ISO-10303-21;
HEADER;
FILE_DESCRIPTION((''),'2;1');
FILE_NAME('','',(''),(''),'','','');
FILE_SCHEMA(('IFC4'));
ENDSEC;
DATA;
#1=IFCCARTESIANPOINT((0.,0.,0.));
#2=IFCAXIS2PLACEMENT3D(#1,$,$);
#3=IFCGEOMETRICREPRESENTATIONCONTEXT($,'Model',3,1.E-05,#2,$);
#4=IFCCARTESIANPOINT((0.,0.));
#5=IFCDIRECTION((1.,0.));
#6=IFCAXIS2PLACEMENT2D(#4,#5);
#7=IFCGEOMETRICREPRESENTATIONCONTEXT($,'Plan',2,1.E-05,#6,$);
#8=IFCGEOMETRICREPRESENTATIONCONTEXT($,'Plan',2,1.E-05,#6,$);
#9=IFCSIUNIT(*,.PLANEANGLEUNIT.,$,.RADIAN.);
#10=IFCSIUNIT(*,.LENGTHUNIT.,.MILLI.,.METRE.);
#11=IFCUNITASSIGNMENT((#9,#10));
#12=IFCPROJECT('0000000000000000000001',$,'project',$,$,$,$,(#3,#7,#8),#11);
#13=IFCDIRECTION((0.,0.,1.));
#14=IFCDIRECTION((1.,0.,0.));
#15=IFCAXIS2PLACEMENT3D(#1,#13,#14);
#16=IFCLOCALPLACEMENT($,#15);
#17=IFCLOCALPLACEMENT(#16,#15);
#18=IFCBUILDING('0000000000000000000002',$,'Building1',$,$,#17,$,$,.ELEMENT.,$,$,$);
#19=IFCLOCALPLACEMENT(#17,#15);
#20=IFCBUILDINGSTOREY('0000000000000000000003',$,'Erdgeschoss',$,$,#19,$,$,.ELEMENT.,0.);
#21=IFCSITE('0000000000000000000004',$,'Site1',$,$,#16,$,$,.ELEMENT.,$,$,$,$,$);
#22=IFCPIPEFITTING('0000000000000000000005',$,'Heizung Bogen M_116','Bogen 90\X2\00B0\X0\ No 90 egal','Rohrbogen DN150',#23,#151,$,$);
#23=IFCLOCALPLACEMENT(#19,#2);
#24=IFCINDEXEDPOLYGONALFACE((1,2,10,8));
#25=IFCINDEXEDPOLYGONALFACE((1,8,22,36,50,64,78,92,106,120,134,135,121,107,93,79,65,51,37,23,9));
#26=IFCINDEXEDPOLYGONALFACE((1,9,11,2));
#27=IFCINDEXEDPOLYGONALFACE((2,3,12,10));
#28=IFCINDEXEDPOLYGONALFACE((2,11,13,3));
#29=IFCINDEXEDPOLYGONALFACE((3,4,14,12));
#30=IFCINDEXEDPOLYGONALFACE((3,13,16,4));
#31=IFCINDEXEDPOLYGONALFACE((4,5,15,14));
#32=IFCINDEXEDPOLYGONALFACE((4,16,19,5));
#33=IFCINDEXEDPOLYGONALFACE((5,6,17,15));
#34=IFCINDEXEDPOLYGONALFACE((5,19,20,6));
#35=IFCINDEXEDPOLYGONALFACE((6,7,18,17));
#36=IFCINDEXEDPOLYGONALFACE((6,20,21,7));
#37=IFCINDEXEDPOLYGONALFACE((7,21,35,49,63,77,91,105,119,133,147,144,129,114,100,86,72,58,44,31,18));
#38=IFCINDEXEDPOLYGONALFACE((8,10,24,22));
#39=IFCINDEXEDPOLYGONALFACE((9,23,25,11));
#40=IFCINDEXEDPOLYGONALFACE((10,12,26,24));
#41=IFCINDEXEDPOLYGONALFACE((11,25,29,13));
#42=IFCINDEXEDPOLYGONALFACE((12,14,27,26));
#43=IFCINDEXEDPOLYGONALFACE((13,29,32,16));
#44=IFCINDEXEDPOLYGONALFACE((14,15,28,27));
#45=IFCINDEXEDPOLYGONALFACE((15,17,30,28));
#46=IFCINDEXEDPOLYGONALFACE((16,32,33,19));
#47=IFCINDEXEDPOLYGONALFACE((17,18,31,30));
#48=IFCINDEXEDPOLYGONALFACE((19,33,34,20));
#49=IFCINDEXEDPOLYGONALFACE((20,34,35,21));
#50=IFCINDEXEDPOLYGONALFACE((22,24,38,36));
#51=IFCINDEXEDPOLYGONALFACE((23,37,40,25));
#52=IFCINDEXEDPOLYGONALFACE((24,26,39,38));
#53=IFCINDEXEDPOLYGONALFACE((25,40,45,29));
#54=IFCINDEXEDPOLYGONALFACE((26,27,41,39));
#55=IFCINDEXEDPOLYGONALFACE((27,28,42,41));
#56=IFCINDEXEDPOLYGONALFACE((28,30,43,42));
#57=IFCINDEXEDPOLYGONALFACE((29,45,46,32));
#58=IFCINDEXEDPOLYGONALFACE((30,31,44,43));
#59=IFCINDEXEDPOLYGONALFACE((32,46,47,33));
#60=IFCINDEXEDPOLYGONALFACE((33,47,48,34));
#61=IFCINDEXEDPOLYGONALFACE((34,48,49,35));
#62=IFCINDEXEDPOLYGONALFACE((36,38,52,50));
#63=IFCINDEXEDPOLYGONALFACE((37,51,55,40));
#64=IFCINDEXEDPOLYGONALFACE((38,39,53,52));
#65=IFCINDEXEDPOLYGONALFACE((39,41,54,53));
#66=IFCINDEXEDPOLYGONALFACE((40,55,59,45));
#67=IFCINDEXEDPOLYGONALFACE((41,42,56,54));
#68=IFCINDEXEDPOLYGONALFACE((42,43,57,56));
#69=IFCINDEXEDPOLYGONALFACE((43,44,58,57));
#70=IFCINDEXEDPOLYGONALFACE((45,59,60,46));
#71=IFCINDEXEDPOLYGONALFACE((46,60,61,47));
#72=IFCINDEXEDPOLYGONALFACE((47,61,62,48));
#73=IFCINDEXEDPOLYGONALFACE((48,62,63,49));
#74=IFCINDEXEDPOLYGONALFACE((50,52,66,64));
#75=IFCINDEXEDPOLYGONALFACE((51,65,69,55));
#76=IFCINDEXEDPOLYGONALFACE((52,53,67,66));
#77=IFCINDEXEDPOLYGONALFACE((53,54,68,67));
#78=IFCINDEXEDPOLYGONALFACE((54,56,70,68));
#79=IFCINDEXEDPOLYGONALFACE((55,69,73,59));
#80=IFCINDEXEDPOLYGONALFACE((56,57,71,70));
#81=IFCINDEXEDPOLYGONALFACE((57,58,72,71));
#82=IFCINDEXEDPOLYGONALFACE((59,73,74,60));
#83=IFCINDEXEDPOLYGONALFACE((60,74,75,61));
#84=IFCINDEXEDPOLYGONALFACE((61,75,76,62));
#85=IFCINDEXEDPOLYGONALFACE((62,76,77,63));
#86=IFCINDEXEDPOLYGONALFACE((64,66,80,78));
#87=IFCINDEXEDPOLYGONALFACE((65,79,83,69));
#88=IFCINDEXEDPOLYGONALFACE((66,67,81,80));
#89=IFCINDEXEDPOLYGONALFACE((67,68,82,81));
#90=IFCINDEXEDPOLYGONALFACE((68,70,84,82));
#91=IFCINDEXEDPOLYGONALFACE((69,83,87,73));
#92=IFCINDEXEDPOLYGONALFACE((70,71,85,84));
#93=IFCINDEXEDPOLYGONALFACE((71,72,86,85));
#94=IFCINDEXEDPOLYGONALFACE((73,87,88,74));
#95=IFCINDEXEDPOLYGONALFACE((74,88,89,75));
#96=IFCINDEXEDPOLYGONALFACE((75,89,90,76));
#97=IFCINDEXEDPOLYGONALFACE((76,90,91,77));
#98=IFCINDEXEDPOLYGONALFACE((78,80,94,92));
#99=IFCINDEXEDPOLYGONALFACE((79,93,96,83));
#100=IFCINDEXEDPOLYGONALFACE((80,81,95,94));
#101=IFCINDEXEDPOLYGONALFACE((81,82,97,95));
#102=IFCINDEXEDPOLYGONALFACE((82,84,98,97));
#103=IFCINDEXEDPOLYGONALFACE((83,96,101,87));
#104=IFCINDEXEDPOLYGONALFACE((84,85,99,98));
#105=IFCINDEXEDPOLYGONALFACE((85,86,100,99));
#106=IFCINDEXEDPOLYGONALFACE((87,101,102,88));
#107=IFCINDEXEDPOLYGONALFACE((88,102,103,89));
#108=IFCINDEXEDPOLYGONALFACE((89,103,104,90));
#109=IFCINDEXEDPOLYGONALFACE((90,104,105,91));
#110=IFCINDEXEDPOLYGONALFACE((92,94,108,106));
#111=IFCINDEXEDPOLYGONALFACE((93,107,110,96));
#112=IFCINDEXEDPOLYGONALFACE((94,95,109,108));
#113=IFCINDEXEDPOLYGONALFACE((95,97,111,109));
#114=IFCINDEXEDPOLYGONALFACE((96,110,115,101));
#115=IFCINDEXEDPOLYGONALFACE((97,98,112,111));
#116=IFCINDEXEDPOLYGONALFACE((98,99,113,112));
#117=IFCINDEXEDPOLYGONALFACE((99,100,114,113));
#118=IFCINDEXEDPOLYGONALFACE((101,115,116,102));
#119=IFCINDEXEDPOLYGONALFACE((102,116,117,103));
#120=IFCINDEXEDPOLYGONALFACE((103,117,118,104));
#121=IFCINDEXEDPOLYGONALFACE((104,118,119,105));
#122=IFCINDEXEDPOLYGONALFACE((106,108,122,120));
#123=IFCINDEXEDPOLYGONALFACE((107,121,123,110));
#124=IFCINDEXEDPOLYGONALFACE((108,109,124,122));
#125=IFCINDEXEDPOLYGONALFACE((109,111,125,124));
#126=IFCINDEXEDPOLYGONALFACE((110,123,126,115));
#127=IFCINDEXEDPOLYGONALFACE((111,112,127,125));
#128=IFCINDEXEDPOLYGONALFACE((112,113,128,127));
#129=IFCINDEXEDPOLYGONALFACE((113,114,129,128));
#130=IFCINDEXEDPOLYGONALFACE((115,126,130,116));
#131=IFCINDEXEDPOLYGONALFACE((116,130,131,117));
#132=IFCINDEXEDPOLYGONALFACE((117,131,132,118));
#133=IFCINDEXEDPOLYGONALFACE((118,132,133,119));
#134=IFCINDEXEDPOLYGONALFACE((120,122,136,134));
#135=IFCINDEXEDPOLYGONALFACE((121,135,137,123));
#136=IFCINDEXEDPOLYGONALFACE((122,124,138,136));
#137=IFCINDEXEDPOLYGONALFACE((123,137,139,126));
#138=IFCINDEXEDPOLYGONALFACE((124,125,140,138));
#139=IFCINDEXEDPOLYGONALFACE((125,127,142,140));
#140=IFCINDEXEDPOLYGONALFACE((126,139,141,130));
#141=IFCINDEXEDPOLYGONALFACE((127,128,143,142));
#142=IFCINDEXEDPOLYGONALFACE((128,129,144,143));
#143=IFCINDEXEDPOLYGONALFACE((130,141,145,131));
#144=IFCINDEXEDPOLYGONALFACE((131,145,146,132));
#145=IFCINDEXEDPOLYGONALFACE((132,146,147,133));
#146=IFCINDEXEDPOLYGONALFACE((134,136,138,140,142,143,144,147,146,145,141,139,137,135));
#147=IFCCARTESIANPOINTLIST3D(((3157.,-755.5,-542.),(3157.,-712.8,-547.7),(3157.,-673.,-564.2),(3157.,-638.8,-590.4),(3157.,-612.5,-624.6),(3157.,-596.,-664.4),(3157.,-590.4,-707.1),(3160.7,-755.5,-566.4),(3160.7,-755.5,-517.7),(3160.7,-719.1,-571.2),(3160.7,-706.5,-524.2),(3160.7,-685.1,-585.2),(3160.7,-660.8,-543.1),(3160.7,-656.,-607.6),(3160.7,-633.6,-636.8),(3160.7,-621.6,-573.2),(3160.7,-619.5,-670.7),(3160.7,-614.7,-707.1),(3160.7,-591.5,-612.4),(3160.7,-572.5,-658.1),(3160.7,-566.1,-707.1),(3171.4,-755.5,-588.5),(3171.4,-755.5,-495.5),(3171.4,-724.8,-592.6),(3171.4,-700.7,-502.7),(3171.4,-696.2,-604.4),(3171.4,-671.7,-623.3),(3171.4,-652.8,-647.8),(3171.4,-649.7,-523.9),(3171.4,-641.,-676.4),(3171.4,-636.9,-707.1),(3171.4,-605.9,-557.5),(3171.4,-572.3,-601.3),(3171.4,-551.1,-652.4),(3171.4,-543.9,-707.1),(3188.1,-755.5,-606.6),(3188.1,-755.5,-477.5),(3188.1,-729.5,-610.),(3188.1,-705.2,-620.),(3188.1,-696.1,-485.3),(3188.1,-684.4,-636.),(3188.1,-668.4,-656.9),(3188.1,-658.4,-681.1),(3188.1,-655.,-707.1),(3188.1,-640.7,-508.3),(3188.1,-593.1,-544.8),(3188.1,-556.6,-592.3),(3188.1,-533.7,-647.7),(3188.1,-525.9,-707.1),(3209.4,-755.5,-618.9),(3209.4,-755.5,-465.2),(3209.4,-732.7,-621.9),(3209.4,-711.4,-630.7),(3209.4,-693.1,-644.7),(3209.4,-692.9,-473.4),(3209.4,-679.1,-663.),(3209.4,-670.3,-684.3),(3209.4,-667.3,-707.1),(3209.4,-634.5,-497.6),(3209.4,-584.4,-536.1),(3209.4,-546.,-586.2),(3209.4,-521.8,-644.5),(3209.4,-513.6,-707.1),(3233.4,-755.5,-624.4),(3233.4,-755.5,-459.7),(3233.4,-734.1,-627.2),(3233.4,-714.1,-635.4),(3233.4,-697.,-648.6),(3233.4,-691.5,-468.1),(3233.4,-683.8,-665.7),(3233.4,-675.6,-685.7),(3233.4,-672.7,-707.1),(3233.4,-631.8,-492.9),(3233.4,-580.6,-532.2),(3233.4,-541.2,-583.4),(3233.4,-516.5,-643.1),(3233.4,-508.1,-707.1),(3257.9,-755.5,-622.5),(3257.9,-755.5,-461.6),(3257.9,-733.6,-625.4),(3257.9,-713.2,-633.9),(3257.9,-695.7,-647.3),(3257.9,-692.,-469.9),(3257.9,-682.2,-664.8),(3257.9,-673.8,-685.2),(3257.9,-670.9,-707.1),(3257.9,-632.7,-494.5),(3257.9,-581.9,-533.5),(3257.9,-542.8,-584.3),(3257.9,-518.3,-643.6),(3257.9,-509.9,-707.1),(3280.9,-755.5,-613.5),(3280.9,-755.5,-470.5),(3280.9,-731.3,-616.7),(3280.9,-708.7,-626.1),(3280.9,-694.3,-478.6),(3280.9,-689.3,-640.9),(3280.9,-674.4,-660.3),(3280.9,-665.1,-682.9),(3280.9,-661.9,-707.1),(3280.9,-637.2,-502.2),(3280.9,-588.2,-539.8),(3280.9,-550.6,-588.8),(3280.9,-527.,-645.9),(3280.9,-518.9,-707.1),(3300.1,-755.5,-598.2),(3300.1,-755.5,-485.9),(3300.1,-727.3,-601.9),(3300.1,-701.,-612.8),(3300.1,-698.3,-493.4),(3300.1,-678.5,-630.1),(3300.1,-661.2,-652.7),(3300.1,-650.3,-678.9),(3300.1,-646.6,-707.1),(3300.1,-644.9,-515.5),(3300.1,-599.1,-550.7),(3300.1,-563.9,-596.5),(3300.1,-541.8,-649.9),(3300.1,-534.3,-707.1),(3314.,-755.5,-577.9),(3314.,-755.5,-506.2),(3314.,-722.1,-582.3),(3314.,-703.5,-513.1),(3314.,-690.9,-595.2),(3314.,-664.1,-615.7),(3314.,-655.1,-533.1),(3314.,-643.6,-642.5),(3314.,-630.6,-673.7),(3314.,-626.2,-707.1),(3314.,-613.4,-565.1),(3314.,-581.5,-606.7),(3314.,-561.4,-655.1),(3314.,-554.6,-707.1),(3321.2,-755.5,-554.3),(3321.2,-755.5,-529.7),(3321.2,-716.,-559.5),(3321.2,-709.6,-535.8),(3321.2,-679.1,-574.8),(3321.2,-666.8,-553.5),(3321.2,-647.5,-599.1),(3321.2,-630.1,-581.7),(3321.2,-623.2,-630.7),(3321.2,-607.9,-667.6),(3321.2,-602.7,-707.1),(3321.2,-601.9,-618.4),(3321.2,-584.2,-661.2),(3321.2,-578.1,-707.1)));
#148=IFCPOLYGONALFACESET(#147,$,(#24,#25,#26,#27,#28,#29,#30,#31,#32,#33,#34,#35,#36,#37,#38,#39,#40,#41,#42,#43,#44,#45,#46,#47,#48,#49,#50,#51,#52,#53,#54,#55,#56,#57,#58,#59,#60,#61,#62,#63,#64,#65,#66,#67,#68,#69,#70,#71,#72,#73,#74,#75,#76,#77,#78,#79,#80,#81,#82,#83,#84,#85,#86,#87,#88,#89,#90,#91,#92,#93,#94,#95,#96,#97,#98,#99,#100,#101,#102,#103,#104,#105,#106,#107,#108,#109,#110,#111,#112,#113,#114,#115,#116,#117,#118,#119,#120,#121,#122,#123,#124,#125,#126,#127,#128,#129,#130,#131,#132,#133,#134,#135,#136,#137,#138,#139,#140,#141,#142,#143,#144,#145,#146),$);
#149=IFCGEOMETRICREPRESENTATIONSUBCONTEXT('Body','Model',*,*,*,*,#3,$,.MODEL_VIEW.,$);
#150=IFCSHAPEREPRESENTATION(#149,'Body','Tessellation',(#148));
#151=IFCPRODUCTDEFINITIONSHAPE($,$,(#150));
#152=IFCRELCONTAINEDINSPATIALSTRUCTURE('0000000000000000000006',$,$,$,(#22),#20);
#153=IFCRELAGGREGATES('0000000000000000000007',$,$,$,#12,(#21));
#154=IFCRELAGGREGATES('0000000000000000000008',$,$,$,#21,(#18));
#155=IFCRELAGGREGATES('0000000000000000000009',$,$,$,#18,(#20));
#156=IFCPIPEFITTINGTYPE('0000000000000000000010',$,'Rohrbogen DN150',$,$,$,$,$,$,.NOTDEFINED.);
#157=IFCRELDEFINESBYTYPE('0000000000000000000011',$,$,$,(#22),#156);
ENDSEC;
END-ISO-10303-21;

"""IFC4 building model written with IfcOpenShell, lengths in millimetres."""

from ifc_helpers import new_model, entity, si_unit, frame, origin, origin_with_axes, origin_2d_with_axis, place, context, subcontext, project, spatial, source, transform, mapped, type_object, element, save


model = new_model("IFC4")

# Units and contexts
model_context = context("Model", 3, precision=1e-05, world=origin())
plan_context_1 = context("Plan", 2, precision=1e-05, world=origin_2d_with_axis())
plan_context_2 = context("Plan", 2, precision=1e-05, world=origin_2d_with_axis())
body_context = subcontext(model_context, "Body", "Model", "MODEL_VIEW")
ifc_project = project(units=[si_unit("PLANEANGLEUNIT", "RADIAN"), si_unit("LENGTHUNIT", "METRE", prefix="MILLI")], contexts=[model_context, plan_context_1, plan_context_2])

# Site, building, storey
site_placement = place(None, origin_with_axes())
site = spatial("IfcSite", under=ifc_project, at=site_placement, Name="Site1", CompositionType="ELEMENT")
building_placement = place(site_placement, origin_with_axes())
building = spatial("IfcBuilding", under=site, at=building_placement, Name="Building1", CompositionType="ELEMENT")
storey_placement = place(building_placement, origin_with_axes())
storey = spatial("IfcBuildingStorey", under=building, at=storey_placement, Name="Erdgeschoss", CompositionType="ELEMENT", Elevation=0.0)

# Pipe fitting
pipe_fitting_type_1 = type_object("IfcPipeFittingType", Name="Rohrbogen DN150", PredefinedType="NOTDEFINED")
shared_shape_1 = source(origin_with_axes(), body_context, "Body", "SolidModel", [
    entity("IfcRevolvedAreaSolid", entity("IfcCircleProfileDef", "AREA", None, entity("IfcAxis2Placement2D", entity("IfcCartesianPoint", [0.0, 0.0]), entity("IfcDirection", [1.0, 0.0])), 82.5), entity("IfcAxis2Placement3D", entity("IfcCartesianPoint", [123.8, 41.3, 0.0]), entity("IfcDirection", [-1.0, 0.0, 0.0]), entity("IfcDirection", [0.0, 0.0, -1.0])), entity("IfcAxis1Placement", entity("IfcCartesianPoint", [0.0, 165.1, 0.0]), entity("IfcDirection", [-1.0, 0.0, 0.0])), 1.570796),
])
pipe_fitting_1_placement = place(storey_placement, frame((3239.6, -631.7, -583.3), z_axis=(0.0, 0.0, 1.0), x_axis=(1.0, 0.0, 0.0)))
element("IfcPipeFitting", 1, at=pipe_fitting_1_placement, inside=storey, type_object=pipe_fitting_type_1, Name="Heizung Bogen M_116", Description="Bogen 90° No 90 egal", ObjectType="Rohrbogen DN150", context=body_context, shape_type="MappedRepresentation", body=[
    mapped(shared_shape_1, transform((0.0, 0.0, 0.0), x_axis=(0.0, 0.0, -1.0), y_axis=(0.0, 1.0, 0.0), z_axis=(1.0, 0.0, 0.0), scale=1.0)),
])

save(model, "model.ifc")
